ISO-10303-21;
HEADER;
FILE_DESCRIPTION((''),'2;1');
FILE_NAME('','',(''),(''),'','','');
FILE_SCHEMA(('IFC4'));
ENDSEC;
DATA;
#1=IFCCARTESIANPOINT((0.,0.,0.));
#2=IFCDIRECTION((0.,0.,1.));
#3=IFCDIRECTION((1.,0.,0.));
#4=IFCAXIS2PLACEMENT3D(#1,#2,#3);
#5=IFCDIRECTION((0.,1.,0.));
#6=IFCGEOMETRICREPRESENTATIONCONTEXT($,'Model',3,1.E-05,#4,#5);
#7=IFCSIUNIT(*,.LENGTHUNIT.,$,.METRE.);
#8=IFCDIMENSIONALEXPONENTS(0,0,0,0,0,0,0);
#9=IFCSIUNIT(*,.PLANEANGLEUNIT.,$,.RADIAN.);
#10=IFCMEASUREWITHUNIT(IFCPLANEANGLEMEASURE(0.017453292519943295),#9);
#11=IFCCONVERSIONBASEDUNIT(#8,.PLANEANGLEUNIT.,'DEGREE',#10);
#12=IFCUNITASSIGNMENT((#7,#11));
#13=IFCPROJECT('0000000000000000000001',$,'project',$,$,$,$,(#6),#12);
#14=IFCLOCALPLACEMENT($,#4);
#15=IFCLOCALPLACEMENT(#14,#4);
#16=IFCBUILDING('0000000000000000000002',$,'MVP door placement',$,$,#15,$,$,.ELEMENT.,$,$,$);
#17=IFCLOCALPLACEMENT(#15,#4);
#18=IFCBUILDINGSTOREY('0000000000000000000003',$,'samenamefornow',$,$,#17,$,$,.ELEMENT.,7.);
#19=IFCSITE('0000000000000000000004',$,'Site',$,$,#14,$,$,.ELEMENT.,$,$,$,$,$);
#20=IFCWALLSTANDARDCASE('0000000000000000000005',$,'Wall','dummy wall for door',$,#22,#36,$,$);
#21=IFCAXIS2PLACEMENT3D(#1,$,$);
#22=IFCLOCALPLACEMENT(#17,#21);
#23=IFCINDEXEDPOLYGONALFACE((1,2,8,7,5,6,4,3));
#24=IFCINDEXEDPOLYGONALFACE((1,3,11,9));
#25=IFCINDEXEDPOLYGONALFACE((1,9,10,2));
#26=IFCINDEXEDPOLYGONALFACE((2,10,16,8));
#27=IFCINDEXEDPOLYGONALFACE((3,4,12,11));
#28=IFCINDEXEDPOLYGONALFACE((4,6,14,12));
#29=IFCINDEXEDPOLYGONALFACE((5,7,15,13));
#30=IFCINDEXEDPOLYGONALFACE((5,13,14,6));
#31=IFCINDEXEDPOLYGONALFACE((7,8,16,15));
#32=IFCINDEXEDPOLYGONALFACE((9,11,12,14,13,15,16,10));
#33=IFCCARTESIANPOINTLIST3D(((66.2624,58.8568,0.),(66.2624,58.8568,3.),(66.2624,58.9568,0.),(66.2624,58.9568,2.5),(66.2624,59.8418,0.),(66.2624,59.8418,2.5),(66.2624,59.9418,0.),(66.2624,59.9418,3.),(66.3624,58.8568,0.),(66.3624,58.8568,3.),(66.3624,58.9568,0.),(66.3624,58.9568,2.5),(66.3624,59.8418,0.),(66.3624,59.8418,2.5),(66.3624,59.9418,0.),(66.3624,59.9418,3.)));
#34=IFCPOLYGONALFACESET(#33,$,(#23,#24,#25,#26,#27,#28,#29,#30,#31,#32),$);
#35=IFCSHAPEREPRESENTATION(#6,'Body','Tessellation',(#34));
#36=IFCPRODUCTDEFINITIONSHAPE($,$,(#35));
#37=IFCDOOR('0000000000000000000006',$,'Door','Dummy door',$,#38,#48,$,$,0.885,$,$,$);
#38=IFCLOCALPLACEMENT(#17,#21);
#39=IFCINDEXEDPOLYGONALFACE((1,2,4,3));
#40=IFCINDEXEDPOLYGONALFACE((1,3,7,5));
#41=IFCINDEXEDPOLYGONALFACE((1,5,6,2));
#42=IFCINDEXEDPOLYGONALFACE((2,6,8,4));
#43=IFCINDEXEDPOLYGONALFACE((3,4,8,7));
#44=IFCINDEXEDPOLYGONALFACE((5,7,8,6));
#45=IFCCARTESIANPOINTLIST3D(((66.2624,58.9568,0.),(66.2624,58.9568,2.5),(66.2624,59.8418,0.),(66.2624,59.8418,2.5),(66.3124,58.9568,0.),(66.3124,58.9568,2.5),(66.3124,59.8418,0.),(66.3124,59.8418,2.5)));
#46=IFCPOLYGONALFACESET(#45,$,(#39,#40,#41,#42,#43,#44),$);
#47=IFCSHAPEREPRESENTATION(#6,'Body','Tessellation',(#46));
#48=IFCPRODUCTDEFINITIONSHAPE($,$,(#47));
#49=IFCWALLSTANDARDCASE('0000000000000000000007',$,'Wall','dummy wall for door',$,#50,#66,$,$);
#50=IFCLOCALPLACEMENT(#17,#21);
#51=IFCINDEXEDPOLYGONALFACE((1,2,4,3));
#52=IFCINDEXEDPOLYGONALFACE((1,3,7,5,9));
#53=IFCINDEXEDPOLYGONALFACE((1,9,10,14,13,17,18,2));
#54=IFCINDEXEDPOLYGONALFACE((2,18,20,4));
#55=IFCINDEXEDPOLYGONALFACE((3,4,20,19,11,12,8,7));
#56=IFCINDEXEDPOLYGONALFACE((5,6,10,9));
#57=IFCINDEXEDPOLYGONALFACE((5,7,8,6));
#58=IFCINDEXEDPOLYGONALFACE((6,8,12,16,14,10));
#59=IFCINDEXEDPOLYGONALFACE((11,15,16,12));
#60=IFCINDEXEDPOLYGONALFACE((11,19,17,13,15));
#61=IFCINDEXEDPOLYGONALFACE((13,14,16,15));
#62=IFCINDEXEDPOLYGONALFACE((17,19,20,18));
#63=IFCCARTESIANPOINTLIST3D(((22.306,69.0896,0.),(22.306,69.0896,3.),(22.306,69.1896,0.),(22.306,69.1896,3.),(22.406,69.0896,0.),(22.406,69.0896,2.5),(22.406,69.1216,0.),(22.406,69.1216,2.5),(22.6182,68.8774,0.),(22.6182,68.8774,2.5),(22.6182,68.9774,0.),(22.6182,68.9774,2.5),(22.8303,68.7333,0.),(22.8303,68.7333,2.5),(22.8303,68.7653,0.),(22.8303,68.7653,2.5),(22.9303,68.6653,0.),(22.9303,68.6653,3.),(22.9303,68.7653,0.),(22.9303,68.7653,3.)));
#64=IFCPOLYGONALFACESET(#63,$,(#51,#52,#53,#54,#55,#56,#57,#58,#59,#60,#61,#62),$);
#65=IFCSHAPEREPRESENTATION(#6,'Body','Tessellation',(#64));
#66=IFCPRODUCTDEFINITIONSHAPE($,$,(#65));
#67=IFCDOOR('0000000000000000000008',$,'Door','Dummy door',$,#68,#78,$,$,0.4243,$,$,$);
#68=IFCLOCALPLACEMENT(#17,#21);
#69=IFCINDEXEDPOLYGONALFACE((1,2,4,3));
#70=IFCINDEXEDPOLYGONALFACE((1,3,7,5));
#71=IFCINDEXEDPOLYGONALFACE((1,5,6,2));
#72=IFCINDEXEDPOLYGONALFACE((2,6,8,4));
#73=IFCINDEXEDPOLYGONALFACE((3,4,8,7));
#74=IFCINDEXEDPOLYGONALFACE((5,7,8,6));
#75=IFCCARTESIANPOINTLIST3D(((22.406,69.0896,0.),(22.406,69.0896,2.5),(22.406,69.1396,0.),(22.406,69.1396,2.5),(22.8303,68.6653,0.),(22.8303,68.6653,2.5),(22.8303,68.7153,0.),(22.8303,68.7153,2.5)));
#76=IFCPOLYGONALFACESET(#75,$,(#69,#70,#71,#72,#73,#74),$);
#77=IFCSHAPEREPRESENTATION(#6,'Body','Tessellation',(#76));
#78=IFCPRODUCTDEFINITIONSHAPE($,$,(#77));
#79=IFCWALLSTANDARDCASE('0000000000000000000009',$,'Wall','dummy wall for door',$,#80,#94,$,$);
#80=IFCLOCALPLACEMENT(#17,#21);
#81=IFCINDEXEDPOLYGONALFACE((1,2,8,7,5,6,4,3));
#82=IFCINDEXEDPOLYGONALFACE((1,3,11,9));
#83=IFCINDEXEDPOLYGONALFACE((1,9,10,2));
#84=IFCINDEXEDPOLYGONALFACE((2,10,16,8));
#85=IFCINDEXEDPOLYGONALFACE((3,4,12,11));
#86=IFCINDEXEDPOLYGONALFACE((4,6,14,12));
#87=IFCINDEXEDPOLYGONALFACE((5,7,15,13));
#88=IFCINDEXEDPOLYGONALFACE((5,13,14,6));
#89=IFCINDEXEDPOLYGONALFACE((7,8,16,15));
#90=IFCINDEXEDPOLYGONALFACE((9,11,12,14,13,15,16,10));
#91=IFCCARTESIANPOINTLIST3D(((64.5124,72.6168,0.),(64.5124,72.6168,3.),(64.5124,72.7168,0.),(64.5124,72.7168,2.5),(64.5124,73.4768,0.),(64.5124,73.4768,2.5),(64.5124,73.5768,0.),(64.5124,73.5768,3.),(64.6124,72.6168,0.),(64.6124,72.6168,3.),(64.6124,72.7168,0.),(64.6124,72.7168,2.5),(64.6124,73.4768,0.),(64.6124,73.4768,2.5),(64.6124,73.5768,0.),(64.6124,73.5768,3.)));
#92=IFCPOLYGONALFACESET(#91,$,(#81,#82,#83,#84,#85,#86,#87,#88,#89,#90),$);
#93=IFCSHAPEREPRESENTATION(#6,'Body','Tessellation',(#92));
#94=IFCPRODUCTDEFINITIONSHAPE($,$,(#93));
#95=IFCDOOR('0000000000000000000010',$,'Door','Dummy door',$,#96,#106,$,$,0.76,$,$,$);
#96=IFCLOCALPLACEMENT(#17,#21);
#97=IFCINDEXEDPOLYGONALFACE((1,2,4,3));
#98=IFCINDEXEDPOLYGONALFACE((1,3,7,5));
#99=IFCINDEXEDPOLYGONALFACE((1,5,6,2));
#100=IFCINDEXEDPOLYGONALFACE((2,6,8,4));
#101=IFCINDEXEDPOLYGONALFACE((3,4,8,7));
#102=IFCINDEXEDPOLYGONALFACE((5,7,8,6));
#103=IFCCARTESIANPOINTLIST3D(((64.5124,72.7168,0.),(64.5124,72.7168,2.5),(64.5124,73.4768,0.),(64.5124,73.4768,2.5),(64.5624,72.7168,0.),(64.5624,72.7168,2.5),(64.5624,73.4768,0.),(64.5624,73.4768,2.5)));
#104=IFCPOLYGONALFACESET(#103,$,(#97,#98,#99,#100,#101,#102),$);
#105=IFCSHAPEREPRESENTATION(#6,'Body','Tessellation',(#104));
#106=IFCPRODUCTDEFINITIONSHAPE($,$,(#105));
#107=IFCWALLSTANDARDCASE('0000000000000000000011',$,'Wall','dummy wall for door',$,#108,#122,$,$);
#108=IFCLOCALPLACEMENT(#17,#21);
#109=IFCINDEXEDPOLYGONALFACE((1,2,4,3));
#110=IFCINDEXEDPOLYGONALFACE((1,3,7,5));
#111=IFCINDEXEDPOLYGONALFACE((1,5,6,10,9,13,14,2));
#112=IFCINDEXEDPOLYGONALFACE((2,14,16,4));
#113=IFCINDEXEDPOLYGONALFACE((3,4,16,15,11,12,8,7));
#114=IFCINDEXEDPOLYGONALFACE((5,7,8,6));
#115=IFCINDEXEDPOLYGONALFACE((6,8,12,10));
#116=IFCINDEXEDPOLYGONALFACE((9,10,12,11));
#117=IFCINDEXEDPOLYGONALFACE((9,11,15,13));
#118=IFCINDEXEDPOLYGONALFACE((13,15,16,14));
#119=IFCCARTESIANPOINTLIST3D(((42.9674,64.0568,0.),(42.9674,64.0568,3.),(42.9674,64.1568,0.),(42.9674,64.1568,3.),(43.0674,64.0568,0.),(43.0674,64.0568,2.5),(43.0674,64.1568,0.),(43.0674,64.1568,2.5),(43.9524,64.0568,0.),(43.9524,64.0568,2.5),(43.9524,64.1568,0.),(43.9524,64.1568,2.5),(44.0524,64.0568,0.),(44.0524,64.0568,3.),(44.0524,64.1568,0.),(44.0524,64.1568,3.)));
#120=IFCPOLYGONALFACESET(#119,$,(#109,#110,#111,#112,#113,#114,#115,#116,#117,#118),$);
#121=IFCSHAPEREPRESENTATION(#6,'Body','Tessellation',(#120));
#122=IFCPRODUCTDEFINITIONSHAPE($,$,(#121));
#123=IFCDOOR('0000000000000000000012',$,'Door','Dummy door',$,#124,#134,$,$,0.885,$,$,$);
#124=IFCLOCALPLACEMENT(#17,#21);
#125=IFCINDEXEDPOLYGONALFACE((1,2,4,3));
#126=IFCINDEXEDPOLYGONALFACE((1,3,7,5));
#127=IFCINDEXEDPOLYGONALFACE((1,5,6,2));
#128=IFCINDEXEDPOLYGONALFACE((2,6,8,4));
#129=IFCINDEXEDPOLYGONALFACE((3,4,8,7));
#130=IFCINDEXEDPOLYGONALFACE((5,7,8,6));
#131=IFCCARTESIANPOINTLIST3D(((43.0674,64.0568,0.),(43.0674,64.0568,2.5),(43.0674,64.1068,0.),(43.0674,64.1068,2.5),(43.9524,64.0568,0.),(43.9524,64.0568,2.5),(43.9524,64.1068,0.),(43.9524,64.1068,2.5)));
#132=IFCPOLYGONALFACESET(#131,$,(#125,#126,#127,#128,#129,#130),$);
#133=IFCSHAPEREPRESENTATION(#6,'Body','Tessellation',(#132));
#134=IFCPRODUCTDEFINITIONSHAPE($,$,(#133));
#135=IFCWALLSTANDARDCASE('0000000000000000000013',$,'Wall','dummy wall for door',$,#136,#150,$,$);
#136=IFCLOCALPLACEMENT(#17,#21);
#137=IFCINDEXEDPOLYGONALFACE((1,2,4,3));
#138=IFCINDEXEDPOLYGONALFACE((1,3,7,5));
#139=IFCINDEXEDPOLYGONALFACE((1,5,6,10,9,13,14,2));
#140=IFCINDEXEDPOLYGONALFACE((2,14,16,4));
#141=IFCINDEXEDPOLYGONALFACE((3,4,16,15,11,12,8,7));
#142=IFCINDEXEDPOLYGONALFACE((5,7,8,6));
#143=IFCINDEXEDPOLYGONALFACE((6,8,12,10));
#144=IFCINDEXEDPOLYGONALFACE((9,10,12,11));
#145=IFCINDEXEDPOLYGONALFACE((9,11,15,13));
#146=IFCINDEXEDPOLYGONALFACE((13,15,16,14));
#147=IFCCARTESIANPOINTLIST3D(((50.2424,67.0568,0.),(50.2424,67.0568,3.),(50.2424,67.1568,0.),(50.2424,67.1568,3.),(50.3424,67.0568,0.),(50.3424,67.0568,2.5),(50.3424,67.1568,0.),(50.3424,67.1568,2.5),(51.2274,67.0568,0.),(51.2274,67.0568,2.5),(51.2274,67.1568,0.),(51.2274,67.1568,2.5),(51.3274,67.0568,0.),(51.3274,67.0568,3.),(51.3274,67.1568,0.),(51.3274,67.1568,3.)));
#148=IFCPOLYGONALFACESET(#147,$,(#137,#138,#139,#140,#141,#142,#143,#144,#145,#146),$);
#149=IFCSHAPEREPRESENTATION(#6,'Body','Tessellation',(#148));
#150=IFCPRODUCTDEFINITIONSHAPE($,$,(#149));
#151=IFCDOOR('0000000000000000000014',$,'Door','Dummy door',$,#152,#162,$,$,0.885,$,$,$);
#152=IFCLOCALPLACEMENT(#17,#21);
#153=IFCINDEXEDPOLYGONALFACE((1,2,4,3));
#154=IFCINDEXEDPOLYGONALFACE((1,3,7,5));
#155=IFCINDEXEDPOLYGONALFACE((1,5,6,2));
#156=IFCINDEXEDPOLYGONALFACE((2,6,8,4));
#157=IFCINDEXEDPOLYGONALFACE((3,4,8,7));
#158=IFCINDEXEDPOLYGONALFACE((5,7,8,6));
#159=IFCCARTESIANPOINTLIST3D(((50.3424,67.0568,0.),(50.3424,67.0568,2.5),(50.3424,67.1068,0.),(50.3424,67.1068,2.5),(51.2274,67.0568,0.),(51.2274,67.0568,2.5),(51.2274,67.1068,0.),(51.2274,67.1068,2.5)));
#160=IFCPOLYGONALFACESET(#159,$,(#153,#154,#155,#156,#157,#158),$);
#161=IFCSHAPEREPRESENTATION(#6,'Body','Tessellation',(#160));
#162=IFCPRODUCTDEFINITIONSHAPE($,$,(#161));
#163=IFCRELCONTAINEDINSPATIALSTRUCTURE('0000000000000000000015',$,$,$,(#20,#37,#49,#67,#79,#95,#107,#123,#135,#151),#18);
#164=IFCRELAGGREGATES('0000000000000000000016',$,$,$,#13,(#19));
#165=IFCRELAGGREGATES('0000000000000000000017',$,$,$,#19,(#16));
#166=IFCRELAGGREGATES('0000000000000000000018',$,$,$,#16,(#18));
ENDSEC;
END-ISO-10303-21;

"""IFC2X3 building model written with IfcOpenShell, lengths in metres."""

from ifc_helpers import new_model, entity, si_unit, converted_unit, direction, origin_with_axes, place, context, project, spatial, polyline, outline, extrude, element, fill, save


model = new_model("IFC2X3")

# Units and contexts
model_context = context("Model", 3, precision=1e-05, world=origin_with_axes(), true_north=direction((0.0, 1.0, 0.0)))
ifc_project = project(units=[si_unit("LENGTHUNIT", "METRE"), converted_unit("PLANEANGLEUNIT", "DEGREE", entity("IfcPlaneAngleMeasure", 0.017453292519943295), si_unit("PLANEANGLEUNIT", "RADIAN"), dimensions=[0, 0, 0, 0, 0, 0, 0])], contexts=[model_context])

# Site, building, storey
site_placement = place(None, origin_with_axes())
site = spatial("IfcSite", under=ifc_project, at=site_placement, Name="Site", CompositionType="ELEMENT")
building_placement = place(site_placement, origin_with_axes())
building = spatial("IfcBuilding", under=site, at=building_placement, Name="MVP door placement", CompositionType="ELEMENT")
storey_placement = place(building_placement, origin_with_axes())
storey = spatial("IfcBuildingStorey", under=building, at=storey_placement, Name="samenamefornow", CompositionType="ELEMENT", Elevation=7.0)

# Walls, openings, doors
wall_1_placement = place(storey_placement, origin_with_axes())
wall_1 = element("IfcWallStandardCase", 1, at=wall_1_placement, inside=storey, Name="Wall", Description="dummy wall for door", context=model_context, shape_type="SweptSolid", body=[
    extrude(outline(polyline([(66.2624, 58.8568, 0.0), (66.2624, 59.9418, 0.0), (66.3624, 59.9418, 0.0), (66.3624, 58.8568, 0.0), (66.2624, 58.8568, 0.0)])), origin_with_axes(), (0.0, 0.0, 1.0), 3.0),
])
opening_1_placement = place(wall_1_placement, origin_with_axes())
opening_1 = element("IfcOpeningElement", 2, at=opening_1_placement, cuts=wall_1, context=model_context, shape_type="SweptSolid", body=[
    extrude(outline(polyline([(66.2624, 58.9568, 0.0), (66.2624, 59.8418, 0.0), (66.3624, 59.8418, 0.0), (66.3624, 58.9568, 0.0), (66.2624, 58.9568, 0.0)])), origin_with_axes(), (0.0, 0.0, 1.0), 2.5),
])
door_1_placement = place(opening_1_placement, origin_with_axes())
door_1 = element("IfcDoor", 3, at=door_1_placement, inside=storey, Name="Door", Description="Dummy door", OverallWidth=0.885, context=model_context, shape_type="SweptSolid", body=[
    extrude(outline(polyline([(66.2624, 58.9568, 0.0), (66.2624, 59.8418, 0.0), (66.3124, 59.8418, 0.0), (66.3124, 58.9568, 0.0), (66.2624, 58.9568, 0.0)])), origin_with_axes(), (0.0, 0.0, 1.0), 2.5),
])
fill(opening_1, door_1)
wall_2_placement = place(storey_placement, origin_with_axes())
wall_2 = element("IfcWallStandardCase", 4, at=wall_2_placement, inside=storey, Name="Wall", Description="dummy wall for door", context=model_context, shape_type="SweptSolid", body=[
    extrude(outline(polyline([(22.306, 69.0896, 0.0), (22.9303, 68.6653, 0.0), (22.9303, 68.7653, 0.0), (22.306, 69.1896, 0.0), (22.306, 69.0896, 0.0)])), origin_with_axes(), (0.0, 0.0, 1.0), 3.0),
])
opening_2_placement = place(wall_2_placement, origin_with_axes())
opening_2 = element("IfcOpeningElement", 5, at=opening_2_placement, cuts=wall_2, context=model_context, shape_type="SweptSolid", body=[
    extrude(outline(polyline([(22.406, 69.0896, 0.0), (22.8303, 68.6653, 0.0), (22.8303, 68.7653, 0.0), (22.406, 69.1896, 0.0), (22.406, 69.0896, 0.0)])), origin_with_axes(), (0.0, 0.0, 1.0), 2.5),
])
door_2_placement = place(opening_2_placement, origin_with_axes())
door_2 = element("IfcDoor", 6, at=door_2_placement, inside=storey, Name="Door", Description="Dummy door", OverallWidth=0.4243, context=model_context, shape_type="SweptSolid", body=[
    extrude(outline(polyline([(22.406, 69.0896, 0.0), (22.8303, 68.6653, 0.0), (22.8303, 68.7153, 0.0), (22.406, 69.1396, 0.0), (22.406, 69.0896, 0.0)])), origin_with_axes(), (0.0, 0.0, 1.0), 2.5),
])
fill(opening_2, door_2)
wall_3_placement = place(storey_placement, origin_with_axes())
wall_3 = element("IfcWallStandardCase", 7, at=wall_3_placement, inside=storey, Name="Wall", Description="dummy wall for door", context=model_context, shape_type="SweptSolid", body=[
    extrude(outline(polyline([(64.5124, 73.5768, 0.0), (64.5124, 72.6168, 0.0), (64.6124, 72.6168, 0.0), (64.6124, 73.5768, 0.0), (64.5124, 73.5768, 0.0)])), origin_with_axes(), (0.0, 0.0, 1.0), 3.0),
])
opening_3_placement = place(wall_3_placement, origin_with_axes())
opening_3 = element("IfcOpeningElement", 8, at=opening_3_placement, cuts=wall_3, context=model_context, shape_type="SweptSolid", body=[
    extrude(outline(polyline([(64.5124, 73.4768, 0.0), (64.5124, 72.7168, 0.0), (64.6124, 72.7168, 0.0), (64.6124, 73.4768, 0.0), (64.5124, 73.4768, 0.0)])), origin_with_axes(), (0.0, 0.0, 1.0), 2.5),
])
door_3_placement = place(opening_3_placement, origin_with_axes())
door_3 = element("IfcDoor", 9, at=door_3_placement, inside=storey, Name="Door", Description="Dummy door", OverallWidth=0.76, context=model_context, shape_type="SweptSolid", body=[
    extrude(outline(polyline([(64.5124, 73.4768, 0.0), (64.5124, 72.7168, 0.0), (64.5624, 72.7168, 0.0), (64.5624, 73.4768, 0.0), (64.5124, 73.4768, 0.0)])), origin_with_axes(), (0.0, 0.0, 1.0), 2.5),
])
fill(opening_3, door_3)
wall_4_placement = place(storey_placement, origin_with_axes())
wall_4 = element("IfcWallStandardCase", 10, at=wall_4_placement, inside=storey, Name="Wall", Description="dummy wall for door", context=model_context, shape_type="SweptSolid", body=[
    extrude(outline(polyline([(42.9674, 64.0568, 0.0), (44.0524, 64.0568, 0.0), (44.0524, 64.1568, 0.0), (42.9674, 64.1568, 0.0), (42.9674, 64.0568, 0.0)])), origin_with_axes(), (0.0, 0.0, 1.0), 3.0),
])
opening_4_placement = place(wall_4_placement, origin_with_axes())
opening_4 = element("IfcOpeningElement", 11, at=opening_4_placement, cuts=wall_4, context=model_context, shape_type="SweptSolid", body=[
    extrude(outline(polyline([(43.0674, 64.0568, 0.0), (43.9524, 64.0568, 0.0), (43.9524, 64.1568, 0.0), (43.0674, 64.1568, 0.0), (43.0674, 64.0568, 0.0)])), origin_with_axes(), (0.0, 0.0, 1.0), 2.5),
])
door_4_placement = place(opening_4_placement, origin_with_axes())
door_4 = element("IfcDoor", 12, at=door_4_placement, inside=storey, Name="Door", Description="Dummy door", OverallWidth=0.885, context=model_context, shape_type="SweptSolid", body=[
    extrude(outline(polyline([(43.0674, 64.0568, 0.0), (43.9524, 64.0568, 0.0), (43.9524, 64.1068, 0.0), (43.0674, 64.1068, 0.0), (43.0674, 64.0568, 0.0)])), origin_with_axes(), (0.0, 0.0, 1.0), 2.5),
])
fill(opening_4, door_4)
wall_5_placement = place(storey_placement, origin_with_axes())
wall_5 = element("IfcWallStandardCase", 13, at=wall_5_placement, inside=storey, Name="Wall", Description="dummy wall for door", context=model_context, shape_type="SweptSolid", body=[
    extrude(outline(polyline([(51.3274, 67.0568, 0.0), (50.2424, 67.0568, 0.0), (50.2424, 67.1568, 0.0), (51.3274, 67.1568, 0.0), (51.3274, 67.0568, 0.0)])), origin_with_axes(), (0.0, 0.0, 1.0), 3.0),
])
opening_5_placement = place(wall_5_placement, origin_with_axes())
opening_5 = element("IfcOpeningElement", 14, at=opening_5_placement, cuts=wall_5, context=model_context, shape_type="SweptSolid", body=[
    extrude(outline(polyline([(51.2274, 67.0568, 0.0), (50.3424, 67.0568, 0.0), (50.3424, 67.1568, 0.0), (51.2274, 67.1568, 0.0), (51.2274, 67.0568, 0.0)])), origin_with_axes(), (0.0, 0.0, 1.0), 2.5),
])
door_5_placement = place(opening_5_placement, origin_with_axes())
door_5 = element("IfcDoor", 15, at=door_5_placement, inside=storey, Name="Door", Description="Dummy door", OverallWidth=0.885, context=model_context, shape_type="SweptSolid", body=[
    extrude(outline(polyline([(51.2274, 67.0568, 0.0), (50.3424, 67.0568, 0.0), (50.3424, 67.1068, 0.0), (51.2274, 67.1068, 0.0), (51.2274, 67.0568, 0.0)])), origin_with_axes(), (0.0, 0.0, 1.0), 2.5),
])
fill(opening_5, door_5)

save(model, "model.ifc")
